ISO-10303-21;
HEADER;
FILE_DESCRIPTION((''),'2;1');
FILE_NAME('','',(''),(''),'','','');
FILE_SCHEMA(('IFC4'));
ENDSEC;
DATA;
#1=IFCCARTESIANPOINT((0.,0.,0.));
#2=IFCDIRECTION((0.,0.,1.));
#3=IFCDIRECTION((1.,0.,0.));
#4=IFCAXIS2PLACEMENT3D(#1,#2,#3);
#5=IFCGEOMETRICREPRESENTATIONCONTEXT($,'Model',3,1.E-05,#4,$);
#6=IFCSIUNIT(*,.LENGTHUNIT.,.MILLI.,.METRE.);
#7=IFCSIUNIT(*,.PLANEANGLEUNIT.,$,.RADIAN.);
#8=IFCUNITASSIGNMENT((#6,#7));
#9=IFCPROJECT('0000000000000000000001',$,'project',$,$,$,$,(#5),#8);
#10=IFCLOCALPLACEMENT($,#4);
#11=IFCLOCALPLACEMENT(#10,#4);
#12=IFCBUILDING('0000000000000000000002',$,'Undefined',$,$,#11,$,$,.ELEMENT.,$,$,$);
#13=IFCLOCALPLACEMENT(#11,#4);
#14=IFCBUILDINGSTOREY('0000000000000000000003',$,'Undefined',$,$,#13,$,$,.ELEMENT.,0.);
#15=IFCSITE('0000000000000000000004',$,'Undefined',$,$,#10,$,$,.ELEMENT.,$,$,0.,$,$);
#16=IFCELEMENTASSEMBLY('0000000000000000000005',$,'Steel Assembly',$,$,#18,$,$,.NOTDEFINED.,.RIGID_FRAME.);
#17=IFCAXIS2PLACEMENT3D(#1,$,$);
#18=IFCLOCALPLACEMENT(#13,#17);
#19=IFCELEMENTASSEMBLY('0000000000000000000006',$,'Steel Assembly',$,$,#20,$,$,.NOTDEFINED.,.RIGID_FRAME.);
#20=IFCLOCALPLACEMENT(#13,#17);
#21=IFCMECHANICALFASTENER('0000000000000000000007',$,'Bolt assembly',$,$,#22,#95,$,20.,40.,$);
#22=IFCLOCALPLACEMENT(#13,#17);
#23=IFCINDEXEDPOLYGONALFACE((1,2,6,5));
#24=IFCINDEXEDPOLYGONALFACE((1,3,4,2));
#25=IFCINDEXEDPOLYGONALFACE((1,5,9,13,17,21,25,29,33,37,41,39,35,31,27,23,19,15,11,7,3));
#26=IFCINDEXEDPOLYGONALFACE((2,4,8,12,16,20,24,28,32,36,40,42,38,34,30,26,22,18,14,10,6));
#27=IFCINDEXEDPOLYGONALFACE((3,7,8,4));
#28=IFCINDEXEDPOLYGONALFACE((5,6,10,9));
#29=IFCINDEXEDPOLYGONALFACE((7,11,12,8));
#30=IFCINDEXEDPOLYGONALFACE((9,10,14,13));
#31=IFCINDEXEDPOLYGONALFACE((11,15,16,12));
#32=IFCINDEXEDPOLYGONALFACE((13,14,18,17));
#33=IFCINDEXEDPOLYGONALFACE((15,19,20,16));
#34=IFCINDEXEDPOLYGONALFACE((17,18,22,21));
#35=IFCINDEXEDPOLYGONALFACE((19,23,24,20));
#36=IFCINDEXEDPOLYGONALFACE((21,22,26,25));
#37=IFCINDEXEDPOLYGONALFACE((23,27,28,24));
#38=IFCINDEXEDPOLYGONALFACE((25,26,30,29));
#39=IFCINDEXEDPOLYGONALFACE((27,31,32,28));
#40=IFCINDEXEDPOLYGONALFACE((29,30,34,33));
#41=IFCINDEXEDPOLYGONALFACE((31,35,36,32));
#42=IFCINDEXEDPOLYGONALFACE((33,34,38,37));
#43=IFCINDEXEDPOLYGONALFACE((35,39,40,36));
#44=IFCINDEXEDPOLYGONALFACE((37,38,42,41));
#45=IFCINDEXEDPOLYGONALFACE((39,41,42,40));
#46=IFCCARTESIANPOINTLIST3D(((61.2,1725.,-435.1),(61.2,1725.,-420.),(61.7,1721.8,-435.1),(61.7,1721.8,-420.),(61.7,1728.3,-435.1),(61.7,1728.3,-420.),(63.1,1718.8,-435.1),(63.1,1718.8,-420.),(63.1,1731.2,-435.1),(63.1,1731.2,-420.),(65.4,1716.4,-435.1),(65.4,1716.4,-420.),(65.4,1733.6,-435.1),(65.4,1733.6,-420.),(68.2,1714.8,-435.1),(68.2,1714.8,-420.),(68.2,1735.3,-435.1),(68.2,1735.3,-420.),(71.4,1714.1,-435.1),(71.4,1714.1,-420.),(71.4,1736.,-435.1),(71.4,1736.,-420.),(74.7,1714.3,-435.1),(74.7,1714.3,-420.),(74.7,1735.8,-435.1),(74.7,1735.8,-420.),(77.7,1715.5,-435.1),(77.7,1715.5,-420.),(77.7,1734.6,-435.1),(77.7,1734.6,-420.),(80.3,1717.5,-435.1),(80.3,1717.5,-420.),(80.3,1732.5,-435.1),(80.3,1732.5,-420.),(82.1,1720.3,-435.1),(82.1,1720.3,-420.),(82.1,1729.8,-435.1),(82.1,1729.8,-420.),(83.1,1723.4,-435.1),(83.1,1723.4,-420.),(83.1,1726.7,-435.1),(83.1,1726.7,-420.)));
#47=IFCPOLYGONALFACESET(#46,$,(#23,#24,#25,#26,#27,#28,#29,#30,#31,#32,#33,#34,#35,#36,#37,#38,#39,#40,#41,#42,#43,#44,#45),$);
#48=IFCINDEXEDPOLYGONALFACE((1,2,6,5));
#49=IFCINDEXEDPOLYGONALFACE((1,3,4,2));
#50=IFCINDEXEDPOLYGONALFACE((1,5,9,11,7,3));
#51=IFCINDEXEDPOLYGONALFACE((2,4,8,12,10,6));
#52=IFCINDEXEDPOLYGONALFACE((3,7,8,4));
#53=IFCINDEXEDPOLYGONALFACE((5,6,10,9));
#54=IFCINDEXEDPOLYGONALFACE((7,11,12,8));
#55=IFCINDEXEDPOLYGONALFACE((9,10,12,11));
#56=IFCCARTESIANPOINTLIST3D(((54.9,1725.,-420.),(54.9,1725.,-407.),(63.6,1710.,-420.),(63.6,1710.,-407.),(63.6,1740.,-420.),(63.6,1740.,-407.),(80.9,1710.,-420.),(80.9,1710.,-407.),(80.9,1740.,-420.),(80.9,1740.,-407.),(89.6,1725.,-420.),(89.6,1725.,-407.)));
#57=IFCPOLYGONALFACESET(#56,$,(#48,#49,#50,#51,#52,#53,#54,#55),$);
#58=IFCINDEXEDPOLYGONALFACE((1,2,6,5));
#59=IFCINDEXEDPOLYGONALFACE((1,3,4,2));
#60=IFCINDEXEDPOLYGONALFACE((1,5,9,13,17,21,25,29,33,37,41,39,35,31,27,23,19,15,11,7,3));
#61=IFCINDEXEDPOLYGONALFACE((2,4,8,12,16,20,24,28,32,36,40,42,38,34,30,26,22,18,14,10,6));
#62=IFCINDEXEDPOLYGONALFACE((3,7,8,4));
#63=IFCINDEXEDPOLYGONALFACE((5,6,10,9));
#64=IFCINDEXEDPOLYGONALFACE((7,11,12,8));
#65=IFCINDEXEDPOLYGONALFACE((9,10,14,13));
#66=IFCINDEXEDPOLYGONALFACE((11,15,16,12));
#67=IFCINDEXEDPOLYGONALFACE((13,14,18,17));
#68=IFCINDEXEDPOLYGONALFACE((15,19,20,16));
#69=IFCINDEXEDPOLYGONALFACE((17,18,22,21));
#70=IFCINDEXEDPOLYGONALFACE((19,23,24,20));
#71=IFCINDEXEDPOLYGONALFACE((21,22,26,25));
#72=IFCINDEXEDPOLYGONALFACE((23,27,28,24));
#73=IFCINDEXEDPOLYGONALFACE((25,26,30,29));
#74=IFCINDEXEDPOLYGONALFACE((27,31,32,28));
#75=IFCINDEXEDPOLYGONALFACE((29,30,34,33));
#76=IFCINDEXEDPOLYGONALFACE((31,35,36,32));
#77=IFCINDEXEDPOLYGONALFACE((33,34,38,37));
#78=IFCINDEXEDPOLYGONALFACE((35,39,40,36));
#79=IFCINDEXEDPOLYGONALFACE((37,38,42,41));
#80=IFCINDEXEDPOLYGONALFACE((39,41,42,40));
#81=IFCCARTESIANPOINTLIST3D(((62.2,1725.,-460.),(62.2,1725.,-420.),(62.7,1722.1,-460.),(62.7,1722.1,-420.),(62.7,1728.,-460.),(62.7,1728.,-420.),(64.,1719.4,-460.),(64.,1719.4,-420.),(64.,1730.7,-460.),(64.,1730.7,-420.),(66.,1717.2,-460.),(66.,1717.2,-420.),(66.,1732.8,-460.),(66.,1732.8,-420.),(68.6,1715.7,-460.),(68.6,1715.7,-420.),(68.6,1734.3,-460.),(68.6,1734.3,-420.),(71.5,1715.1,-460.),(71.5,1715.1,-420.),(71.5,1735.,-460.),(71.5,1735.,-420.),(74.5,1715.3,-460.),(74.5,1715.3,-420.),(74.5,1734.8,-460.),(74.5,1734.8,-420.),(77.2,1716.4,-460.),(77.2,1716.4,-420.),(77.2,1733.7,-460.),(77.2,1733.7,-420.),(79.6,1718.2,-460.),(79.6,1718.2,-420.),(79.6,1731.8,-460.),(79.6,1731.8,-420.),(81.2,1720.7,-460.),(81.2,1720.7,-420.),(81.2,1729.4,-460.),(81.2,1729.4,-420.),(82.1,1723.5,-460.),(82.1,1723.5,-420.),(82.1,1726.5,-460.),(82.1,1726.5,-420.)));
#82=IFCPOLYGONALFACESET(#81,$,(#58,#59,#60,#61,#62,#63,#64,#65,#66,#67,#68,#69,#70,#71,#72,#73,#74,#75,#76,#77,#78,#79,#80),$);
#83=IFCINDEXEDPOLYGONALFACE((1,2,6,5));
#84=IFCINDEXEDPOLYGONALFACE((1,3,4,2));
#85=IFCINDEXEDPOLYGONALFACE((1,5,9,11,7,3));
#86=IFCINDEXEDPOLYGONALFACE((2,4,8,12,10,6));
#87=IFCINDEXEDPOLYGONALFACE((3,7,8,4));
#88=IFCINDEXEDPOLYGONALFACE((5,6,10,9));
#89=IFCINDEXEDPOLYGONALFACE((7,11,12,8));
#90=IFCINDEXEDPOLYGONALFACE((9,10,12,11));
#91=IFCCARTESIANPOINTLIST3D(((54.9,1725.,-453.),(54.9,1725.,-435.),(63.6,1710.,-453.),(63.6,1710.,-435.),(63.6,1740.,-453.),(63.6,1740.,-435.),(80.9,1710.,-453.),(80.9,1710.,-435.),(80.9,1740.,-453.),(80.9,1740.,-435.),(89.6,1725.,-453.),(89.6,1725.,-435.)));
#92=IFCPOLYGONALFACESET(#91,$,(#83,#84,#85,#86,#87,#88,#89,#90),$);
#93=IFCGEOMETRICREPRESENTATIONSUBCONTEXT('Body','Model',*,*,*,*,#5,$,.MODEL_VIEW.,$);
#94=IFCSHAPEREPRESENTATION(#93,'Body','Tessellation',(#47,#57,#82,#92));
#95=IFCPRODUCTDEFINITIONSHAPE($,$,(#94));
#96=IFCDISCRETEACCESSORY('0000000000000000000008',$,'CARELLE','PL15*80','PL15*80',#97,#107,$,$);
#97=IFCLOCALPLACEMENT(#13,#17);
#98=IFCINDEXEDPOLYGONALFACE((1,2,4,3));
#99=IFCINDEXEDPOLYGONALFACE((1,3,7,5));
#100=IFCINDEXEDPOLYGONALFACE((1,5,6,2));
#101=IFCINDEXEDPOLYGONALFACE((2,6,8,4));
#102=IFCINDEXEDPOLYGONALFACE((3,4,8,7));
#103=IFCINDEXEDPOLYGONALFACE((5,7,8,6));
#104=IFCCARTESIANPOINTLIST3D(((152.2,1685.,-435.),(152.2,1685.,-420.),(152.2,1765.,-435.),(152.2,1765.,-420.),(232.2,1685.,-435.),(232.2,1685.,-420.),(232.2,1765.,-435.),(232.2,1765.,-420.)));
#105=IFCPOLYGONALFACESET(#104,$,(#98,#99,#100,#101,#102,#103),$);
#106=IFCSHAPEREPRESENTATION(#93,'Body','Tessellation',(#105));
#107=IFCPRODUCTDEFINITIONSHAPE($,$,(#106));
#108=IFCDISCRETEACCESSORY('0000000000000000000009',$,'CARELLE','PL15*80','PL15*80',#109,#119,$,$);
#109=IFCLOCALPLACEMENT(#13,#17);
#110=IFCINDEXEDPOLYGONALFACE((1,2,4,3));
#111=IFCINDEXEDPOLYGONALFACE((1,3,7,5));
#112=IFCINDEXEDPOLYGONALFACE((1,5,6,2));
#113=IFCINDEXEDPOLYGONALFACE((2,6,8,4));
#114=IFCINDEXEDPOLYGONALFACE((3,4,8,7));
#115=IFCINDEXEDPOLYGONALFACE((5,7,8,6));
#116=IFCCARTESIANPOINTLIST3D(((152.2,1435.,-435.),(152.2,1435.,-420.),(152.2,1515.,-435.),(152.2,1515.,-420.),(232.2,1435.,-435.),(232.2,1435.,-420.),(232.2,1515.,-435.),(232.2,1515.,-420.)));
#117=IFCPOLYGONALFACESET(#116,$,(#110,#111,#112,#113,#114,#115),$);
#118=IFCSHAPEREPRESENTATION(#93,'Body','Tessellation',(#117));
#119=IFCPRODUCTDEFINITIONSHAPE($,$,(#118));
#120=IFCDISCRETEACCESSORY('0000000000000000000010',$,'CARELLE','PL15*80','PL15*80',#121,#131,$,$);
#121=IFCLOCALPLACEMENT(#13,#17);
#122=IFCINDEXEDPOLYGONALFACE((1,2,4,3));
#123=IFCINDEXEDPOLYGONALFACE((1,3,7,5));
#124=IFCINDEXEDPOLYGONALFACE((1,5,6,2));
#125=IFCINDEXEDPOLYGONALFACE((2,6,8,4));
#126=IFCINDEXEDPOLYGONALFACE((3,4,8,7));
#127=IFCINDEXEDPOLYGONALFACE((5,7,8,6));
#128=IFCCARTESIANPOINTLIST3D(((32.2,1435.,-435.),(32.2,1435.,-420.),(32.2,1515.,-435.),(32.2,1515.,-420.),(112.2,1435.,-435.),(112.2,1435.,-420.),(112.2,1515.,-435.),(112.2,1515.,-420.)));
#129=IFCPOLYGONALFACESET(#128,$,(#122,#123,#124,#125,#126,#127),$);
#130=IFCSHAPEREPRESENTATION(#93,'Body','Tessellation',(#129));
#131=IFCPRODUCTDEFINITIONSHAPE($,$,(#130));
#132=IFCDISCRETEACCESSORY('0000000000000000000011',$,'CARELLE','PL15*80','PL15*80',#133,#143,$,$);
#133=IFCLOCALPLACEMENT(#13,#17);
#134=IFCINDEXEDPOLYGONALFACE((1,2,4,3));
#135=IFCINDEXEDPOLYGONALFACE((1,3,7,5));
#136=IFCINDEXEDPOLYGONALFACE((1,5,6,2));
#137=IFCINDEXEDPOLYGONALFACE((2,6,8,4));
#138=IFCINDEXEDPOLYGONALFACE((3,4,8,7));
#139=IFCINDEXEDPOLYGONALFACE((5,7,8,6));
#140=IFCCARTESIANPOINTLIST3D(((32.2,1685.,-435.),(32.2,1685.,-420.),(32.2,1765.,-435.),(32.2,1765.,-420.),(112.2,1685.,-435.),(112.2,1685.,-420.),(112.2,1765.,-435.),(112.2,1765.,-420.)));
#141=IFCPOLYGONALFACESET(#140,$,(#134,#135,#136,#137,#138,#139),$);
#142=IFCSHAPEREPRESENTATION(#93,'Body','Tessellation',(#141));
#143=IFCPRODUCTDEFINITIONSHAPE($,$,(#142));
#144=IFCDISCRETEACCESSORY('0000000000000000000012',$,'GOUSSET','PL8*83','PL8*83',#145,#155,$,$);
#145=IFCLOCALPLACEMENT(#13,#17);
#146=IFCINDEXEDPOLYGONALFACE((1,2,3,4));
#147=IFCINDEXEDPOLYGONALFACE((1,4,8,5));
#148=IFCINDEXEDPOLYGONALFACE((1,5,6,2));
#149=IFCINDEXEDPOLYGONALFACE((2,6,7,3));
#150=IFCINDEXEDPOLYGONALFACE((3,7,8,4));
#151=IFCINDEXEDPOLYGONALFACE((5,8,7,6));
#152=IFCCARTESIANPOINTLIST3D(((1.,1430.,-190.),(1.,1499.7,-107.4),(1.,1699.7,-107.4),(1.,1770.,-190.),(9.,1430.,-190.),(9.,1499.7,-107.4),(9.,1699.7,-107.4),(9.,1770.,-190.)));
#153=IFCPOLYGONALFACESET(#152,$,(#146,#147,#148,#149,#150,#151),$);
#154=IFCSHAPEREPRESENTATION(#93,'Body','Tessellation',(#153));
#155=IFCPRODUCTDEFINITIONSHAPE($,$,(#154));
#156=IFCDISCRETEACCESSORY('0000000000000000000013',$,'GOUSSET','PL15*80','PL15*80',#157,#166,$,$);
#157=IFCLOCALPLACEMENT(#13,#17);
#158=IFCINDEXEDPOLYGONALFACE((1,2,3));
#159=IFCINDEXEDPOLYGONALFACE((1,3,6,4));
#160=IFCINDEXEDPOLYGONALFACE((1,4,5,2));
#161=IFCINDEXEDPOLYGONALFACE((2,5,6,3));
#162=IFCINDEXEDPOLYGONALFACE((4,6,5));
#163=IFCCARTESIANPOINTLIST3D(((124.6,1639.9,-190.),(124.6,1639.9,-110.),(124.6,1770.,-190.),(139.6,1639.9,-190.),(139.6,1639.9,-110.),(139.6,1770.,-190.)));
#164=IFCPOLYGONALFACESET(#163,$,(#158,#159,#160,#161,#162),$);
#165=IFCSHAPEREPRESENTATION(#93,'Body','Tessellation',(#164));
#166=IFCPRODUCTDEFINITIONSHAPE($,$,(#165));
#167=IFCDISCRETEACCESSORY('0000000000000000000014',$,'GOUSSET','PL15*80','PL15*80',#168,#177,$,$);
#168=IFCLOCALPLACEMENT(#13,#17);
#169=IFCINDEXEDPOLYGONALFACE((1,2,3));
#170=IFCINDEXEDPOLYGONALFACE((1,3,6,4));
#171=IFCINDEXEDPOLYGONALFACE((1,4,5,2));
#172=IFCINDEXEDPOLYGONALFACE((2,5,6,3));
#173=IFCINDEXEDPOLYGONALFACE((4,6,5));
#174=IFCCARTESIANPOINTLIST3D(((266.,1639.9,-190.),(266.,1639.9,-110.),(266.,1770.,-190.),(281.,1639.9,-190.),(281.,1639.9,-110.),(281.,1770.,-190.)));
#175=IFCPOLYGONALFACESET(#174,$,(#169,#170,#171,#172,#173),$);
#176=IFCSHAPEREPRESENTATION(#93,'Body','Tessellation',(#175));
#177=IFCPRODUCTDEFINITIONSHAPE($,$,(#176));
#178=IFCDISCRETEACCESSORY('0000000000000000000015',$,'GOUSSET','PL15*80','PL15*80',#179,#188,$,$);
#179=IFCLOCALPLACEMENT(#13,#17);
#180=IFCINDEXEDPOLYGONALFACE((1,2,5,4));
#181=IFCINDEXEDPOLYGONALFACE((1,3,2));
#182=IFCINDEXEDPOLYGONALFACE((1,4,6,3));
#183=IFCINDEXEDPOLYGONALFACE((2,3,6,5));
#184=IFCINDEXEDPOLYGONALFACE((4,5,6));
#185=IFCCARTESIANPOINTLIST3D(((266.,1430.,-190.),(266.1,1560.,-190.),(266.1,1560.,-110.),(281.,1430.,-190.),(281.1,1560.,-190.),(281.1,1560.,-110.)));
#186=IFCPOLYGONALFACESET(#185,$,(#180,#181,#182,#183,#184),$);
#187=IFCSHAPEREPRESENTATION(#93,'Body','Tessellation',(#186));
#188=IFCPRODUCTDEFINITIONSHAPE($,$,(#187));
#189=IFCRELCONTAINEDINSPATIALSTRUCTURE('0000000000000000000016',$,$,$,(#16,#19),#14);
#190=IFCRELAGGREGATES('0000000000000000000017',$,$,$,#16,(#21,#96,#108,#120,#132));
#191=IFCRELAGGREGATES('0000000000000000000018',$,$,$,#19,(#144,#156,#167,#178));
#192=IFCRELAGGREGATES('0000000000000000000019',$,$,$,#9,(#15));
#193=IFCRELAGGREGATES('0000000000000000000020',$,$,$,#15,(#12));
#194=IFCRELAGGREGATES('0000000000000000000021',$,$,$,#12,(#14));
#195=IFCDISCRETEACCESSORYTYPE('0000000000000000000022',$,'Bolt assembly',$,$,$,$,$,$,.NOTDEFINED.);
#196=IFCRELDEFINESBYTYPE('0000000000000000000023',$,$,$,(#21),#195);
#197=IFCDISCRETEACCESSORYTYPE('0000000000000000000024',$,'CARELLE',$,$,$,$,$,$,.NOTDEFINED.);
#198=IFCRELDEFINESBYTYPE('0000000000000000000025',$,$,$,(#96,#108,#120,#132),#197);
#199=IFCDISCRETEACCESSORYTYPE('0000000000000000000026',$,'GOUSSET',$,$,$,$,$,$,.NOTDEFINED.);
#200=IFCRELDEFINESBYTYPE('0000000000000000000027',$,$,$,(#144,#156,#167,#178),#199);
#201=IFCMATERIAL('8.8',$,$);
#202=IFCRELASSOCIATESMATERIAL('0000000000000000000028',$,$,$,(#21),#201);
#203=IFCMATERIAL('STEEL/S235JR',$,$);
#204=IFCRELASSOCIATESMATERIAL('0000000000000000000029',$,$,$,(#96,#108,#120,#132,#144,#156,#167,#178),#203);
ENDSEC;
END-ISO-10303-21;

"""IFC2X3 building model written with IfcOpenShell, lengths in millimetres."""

from ifc_helpers import new_model, si_unit, frame, origin_with_axes, origin_2d_with_axis, place, context, subcontext, project, spatial, polyline, circle, outline, extrude, source, transform, mapped, material, type_object, element, aggregate, save


model = new_model("IFC2X3")

# Units and contexts
model_context = context("Model", 3, precision=1e-05, world=origin_with_axes())
body_context = subcontext(model_context, "Body", "Model", "MODEL_VIEW")
ifc_project = project(units=[si_unit("LENGTHUNIT", "METRE", prefix="MILLI"), si_unit("PLANEANGLEUNIT", "RADIAN")], contexts=[model_context])

# Site, building, storey
site_placement = place(None, origin_with_axes())
site = spatial("IfcSite", under=ifc_project, at=site_placement, Name="Undefined", CompositionType="ELEMENT", RefElevation=0.0)
building_placement = place(site_placement, origin_with_axes())
building = spatial("IfcBuilding", under=site, at=building_placement, Name="Undefined", CompositionType="ELEMENT")
storey_placement = place(building_placement, origin_with_axes())
storey = spatial("IfcBuildingStorey", under=building, at=storey_placement, Name="Undefined", CompositionType="ELEMENT", Elevation=0.0)

# Element assembly
ifc_material_1 = material(Name="STEEL/S235JR")
assembly_1_placement = place(storey_placement, origin_with_axes())
assembly_1 = element("IfcElementAssembly", 1, at=assembly_1_placement, inside=storey, Name="Steel Assembly", AssemblyPlace="NOTDEFINED", PredefinedType="RIGID_FRAME")

# Element assembly
assembly_2_placement = place(storey_placement, origin_with_axes())
assembly_2 = element("IfcElementAssembly", 2, at=assembly_2_placement, inside=storey, Name="Steel Assembly", AssemblyPlace="NOTDEFINED", PredefinedType="RIGID_FRAME")

# Mechanical fastener
ifc_material_2 = material(Name="8.8")
discrete_accessory_type_1 = type_object("IfcDiscreteAccessoryType", Name="Bolt assembly")
shared_shape_1 = source(origin_with_axes(), body_context, "Body", "SweptSolid", [
    extrude(circle(Radius=11.0, at=origin_2d_with_axis()), frame((0.0, 0.0, 0.0), z_axis=(0.0, 1.0, 0.0), x_axis=(1.0, 0.0, 0.0)), (0.0, 0.0, 1.0), 15.1),
    extrude(outline(polyline([(17.3, 0.0), (8.7, 15.0), (-8.7, 15.0), (-17.3, 0.0), (-8.7, -15.0), (8.7, -15.0), (17.3, 0.0)])), frame((0.0, -13.0, 0.0), z_axis=(0.0, 1.0, 0.0), x_axis=(1.0, 0.0, 0.0)), (0.0, 0.0, 1.0), 13.0),
    extrude(circle(Radius=10.0, at=origin_2d_with_axis()), frame((0.0, 0.0, 0.0), z_axis=(0.0, 1.0, 0.0), x_axis=(1.0, 0.0, 0.0)), (0.0, 0.0, 1.0), 40.0),
    extrude(outline(polyline([(17.3, 0.0), (8.7, 15.0), (-8.7, 15.0), (-17.3, 0.0), (-8.7, -15.0), (8.7, -15.0), (17.3, 0.0)])), frame((0.0, 15.0, 0.0), z_axis=(0.0, 1.0, 0.0), x_axis=(1.0, 0.0, 0.0)), (0.0, 0.0, 1.0), 18.0),
])
mechanical_fastener_1_placement = place(assembly_1_placement, frame((72.2, 1725.0, -420.0), z_axis=(0.0, -1.0, 0.0), x_axis=(-1.0, 0.0, 0.0)))
mechanical_fastener_1 = element("IfcMechanicalFastener", 3, at=mechanical_fastener_1_placement, type_object=discrete_accessory_type_1, material=ifc_material_2, Name="Bolt assembly", NominalDiameter=20.0, NominalLength=40.0, context=body_context, shape_type="MappedRepresentation", body=[
    mapped(shared_shape_1, transform((0.0, 0.0, 0.0))),
])

# Discrete accessories
discrete_accessory_type_2 = type_object("IfcDiscreteAccessoryType", Name="CARELLE")
discrete_accessory_1_placement = place(assembly_1_placement, frame((232.2, 1765.0, -427.5), z_axis=(0.0, 0.0, 1.0), x_axis=(-1.0, 0.0, 0.0)))
discrete_accessory_1 = element("IfcDiscreteAccessory", 4, at=discrete_accessory_1_placement, type_object=discrete_accessory_type_2, material=ifc_material_1, Name="CARELLE", Description="PL15*80", ObjectType="PL15*80", context=body_context, shape_type="SweptSolid", body=[
    extrude(outline(polyline([(0.0, 0.0), (80.0, 0.0), (80.0, 80.0), (0.0, 80.0), (0.0, 0.0)])), frame((0.0, 0.0, -7.5), z_axis=(0.0, 0.0, 1.0), x_axis=(1.0, 0.0, 0.0)), (0.0, 0.0, 1.0), 15.0),
])
discrete_accessory_2_placement = place(assembly_1_placement, frame((232.2, 1515.0, -427.5), z_axis=(0.0, 0.0, 1.0), x_axis=(-1.0, 0.0, 0.0)))
discrete_accessory_2 = element("IfcDiscreteAccessory", 5, at=discrete_accessory_2_placement, type_object=discrete_accessory_type_2, material=ifc_material_1, Name="CARELLE", Description="PL15*80", ObjectType="PL15*80", context=body_context, shape_type="SweptSolid", body=[
    extrude(outline(polyline([(0.0, 0.0), (80.0, 0.0), (80.0, 80.0), (0.0, 80.0), (0.0, 0.0)])), frame((0.0, 0.0, -7.5), z_axis=(0.0, 0.0, 1.0), x_axis=(1.0, 0.0, 0.0)), (0.0, 0.0, 1.0), 15.0),
])
discrete_accessory_3_placement = place(assembly_1_placement, frame((112.2, 1515.0, -427.5), z_axis=(0.0, 0.0, 1.0), x_axis=(-1.0, 0.0, 0.0)))
discrete_accessory_3 = element("IfcDiscreteAccessory", 6, at=discrete_accessory_3_placement, type_object=discrete_accessory_type_2, material=ifc_material_1, Name="CARELLE", Description="PL15*80", ObjectType="PL15*80", context=body_context, shape_type="SweptSolid", body=[
    extrude(outline(polyline([(0.0, 0.0), (80.0, 0.0), (80.0, 80.0), (0.0, 80.0), (0.0, 0.0)])), frame((0.0, 0.0, -7.5), z_axis=(0.0, 0.0, 1.0), x_axis=(1.0, 0.0, 0.0)), (0.0, 0.0, 1.0), 15.0),
])
discrete_accessory_4_placement = place(assembly_1_placement, frame((112.2, 1765.0, -427.5), z_axis=(0.0, 0.0, 1.0), x_axis=(-1.0, 0.0, 0.0)))
discrete_accessory_4 = element("IfcDiscreteAccessory", 7, at=discrete_accessory_4_placement, type_object=discrete_accessory_type_2, material=ifc_material_1, Name="CARELLE", Description="PL15*80", ObjectType="PL15*80", context=body_context, shape_type="SweptSolid", body=[
    extrude(outline(polyline([(0.0, 0.0), (80.0, 0.0), (80.0, 80.0), (0.0, 80.0), (0.0, 0.0)])), frame((0.0, 0.0, -7.5), z_axis=(0.0, 0.0, 1.0), x_axis=(1.0, 0.0, 0.0)), (0.0, 0.0, 1.0), 15.0),
])
aggregate(assembly_1, [mechanical_fastener_1, discrete_accessory_1, discrete_accessory_2, discrete_accessory_3, discrete_accessory_4])
discrete_accessory_type_3 = type_object("IfcDiscreteAccessoryType", Name="GOUSSET")
discrete_accessory_5_placement = place(assembly_2_placement, frame((5.0, 1430.0, -190.0), z_axis=(-1.0, -0.000005, 0.0), x_axis=(-0.000003, 0.645014, 0.764171)))
discrete_accessory_5 = element("IfcDiscreteAccessory", 8, at=discrete_accessory_5_placement, type_object=discrete_accessory_type_3, material=ifc_material_1, Name="GOUSSET", Description="PL8*83", ObjectType="PL8*83", context=body_context, shape_type="SweptSolid", body=[
    extrude(outline(polyline([(0.0, 0.0), (108.0, 0.0), (237.0, 152.8), (219.3, 259.8), (0.0, 0.0)])), frame((0.0, 0.0, -4.0), z_axis=(0.0, 0.0, 1.0), x_axis=(1.0, 0.0, 0.0)), (0.0, 0.0, 1.0), 8.0),
])
discrete_accessory_6_placement = place(assembly_2_placement, frame((132.1, 1770.0, -190.0), z_axis=(-1.0, -0.000005, 0.0), x_axis=(0.000005, -1.0, 0.0)))
discrete_accessory_6 = element("IfcDiscreteAccessory", 9, at=discrete_accessory_6_placement, type_object=discrete_accessory_type_3, material=ifc_material_1, Name="GOUSSET", Description="PL15*80", ObjectType="PL15*80", context=body_context, shape_type="SweptSolid", body=[
    extrude(outline(polyline([(0.0, 0.0), (130.1, 0.0), (130.1, 80.0), (0.0, 0.0)])), frame((0.0, 0.0, -7.5), z_axis=(0.0, 0.0, 1.0), x_axis=(1.0, 0.0, 0.0)), (0.0, 0.0, 1.0), 15.0),
])
discrete_accessory_7_placement = place(assembly_2_placement, frame((273.5, 1770.0, -190.0), z_axis=(-1.0, -0.000005, 0.0), x_axis=(0.000005, -1.0, 0.0)))
discrete_accessory_7 = element("IfcDiscreteAccessory", 10, at=discrete_accessory_7_placement, type_object=discrete_accessory_type_3, material=ifc_material_1, Name="GOUSSET", Description="PL15*80", ObjectType="PL15*80", context=body_context, shape_type="SweptSolid", body=[
    extrude(outline(polyline([(0.0, 0.0), (130.1, 0.0), (130.1, 80.0), (0.0, 0.0)])), frame((0.0, 0.0, -7.5), z_axis=(0.0, 0.0, 1.0), x_axis=(1.0, 0.0, 0.0)), (0.0, 0.0, 1.0), 15.0),
])
discrete_accessory_8_placement = place(assembly_2_placement, frame((273.6, 1560.0, -190.0), z_axis=(-1.0, 0.000542, 0.0), x_axis=(-0.000542, -1.0, 0.0)))
discrete_accessory_8 = element("IfcDiscreteAccessory", 11, at=discrete_accessory_8_placement, type_object=discrete_accessory_type_3, material=ifc_material_1, Name="GOUSSET", Description="PL15*80", ObjectType="PL15*80", context=body_context, shape_type="SweptSolid", body=[
    extrude(outline(polyline([(0.0, 0.0), (130.0, 0.0), (0.0, 80.0), (0.0, 0.0)])), frame((0.0, 0.0, -7.5), z_axis=(0.0, 0.0, 1.0), x_axis=(1.0, 0.0, 0.0)), (0.0, 0.0, 1.0), 15.0),
])
aggregate(assembly_2, [discrete_accessory_5, discrete_accessory_6, discrete_accessory_7, discrete_accessory_8])

save(model, "model.ifc")
